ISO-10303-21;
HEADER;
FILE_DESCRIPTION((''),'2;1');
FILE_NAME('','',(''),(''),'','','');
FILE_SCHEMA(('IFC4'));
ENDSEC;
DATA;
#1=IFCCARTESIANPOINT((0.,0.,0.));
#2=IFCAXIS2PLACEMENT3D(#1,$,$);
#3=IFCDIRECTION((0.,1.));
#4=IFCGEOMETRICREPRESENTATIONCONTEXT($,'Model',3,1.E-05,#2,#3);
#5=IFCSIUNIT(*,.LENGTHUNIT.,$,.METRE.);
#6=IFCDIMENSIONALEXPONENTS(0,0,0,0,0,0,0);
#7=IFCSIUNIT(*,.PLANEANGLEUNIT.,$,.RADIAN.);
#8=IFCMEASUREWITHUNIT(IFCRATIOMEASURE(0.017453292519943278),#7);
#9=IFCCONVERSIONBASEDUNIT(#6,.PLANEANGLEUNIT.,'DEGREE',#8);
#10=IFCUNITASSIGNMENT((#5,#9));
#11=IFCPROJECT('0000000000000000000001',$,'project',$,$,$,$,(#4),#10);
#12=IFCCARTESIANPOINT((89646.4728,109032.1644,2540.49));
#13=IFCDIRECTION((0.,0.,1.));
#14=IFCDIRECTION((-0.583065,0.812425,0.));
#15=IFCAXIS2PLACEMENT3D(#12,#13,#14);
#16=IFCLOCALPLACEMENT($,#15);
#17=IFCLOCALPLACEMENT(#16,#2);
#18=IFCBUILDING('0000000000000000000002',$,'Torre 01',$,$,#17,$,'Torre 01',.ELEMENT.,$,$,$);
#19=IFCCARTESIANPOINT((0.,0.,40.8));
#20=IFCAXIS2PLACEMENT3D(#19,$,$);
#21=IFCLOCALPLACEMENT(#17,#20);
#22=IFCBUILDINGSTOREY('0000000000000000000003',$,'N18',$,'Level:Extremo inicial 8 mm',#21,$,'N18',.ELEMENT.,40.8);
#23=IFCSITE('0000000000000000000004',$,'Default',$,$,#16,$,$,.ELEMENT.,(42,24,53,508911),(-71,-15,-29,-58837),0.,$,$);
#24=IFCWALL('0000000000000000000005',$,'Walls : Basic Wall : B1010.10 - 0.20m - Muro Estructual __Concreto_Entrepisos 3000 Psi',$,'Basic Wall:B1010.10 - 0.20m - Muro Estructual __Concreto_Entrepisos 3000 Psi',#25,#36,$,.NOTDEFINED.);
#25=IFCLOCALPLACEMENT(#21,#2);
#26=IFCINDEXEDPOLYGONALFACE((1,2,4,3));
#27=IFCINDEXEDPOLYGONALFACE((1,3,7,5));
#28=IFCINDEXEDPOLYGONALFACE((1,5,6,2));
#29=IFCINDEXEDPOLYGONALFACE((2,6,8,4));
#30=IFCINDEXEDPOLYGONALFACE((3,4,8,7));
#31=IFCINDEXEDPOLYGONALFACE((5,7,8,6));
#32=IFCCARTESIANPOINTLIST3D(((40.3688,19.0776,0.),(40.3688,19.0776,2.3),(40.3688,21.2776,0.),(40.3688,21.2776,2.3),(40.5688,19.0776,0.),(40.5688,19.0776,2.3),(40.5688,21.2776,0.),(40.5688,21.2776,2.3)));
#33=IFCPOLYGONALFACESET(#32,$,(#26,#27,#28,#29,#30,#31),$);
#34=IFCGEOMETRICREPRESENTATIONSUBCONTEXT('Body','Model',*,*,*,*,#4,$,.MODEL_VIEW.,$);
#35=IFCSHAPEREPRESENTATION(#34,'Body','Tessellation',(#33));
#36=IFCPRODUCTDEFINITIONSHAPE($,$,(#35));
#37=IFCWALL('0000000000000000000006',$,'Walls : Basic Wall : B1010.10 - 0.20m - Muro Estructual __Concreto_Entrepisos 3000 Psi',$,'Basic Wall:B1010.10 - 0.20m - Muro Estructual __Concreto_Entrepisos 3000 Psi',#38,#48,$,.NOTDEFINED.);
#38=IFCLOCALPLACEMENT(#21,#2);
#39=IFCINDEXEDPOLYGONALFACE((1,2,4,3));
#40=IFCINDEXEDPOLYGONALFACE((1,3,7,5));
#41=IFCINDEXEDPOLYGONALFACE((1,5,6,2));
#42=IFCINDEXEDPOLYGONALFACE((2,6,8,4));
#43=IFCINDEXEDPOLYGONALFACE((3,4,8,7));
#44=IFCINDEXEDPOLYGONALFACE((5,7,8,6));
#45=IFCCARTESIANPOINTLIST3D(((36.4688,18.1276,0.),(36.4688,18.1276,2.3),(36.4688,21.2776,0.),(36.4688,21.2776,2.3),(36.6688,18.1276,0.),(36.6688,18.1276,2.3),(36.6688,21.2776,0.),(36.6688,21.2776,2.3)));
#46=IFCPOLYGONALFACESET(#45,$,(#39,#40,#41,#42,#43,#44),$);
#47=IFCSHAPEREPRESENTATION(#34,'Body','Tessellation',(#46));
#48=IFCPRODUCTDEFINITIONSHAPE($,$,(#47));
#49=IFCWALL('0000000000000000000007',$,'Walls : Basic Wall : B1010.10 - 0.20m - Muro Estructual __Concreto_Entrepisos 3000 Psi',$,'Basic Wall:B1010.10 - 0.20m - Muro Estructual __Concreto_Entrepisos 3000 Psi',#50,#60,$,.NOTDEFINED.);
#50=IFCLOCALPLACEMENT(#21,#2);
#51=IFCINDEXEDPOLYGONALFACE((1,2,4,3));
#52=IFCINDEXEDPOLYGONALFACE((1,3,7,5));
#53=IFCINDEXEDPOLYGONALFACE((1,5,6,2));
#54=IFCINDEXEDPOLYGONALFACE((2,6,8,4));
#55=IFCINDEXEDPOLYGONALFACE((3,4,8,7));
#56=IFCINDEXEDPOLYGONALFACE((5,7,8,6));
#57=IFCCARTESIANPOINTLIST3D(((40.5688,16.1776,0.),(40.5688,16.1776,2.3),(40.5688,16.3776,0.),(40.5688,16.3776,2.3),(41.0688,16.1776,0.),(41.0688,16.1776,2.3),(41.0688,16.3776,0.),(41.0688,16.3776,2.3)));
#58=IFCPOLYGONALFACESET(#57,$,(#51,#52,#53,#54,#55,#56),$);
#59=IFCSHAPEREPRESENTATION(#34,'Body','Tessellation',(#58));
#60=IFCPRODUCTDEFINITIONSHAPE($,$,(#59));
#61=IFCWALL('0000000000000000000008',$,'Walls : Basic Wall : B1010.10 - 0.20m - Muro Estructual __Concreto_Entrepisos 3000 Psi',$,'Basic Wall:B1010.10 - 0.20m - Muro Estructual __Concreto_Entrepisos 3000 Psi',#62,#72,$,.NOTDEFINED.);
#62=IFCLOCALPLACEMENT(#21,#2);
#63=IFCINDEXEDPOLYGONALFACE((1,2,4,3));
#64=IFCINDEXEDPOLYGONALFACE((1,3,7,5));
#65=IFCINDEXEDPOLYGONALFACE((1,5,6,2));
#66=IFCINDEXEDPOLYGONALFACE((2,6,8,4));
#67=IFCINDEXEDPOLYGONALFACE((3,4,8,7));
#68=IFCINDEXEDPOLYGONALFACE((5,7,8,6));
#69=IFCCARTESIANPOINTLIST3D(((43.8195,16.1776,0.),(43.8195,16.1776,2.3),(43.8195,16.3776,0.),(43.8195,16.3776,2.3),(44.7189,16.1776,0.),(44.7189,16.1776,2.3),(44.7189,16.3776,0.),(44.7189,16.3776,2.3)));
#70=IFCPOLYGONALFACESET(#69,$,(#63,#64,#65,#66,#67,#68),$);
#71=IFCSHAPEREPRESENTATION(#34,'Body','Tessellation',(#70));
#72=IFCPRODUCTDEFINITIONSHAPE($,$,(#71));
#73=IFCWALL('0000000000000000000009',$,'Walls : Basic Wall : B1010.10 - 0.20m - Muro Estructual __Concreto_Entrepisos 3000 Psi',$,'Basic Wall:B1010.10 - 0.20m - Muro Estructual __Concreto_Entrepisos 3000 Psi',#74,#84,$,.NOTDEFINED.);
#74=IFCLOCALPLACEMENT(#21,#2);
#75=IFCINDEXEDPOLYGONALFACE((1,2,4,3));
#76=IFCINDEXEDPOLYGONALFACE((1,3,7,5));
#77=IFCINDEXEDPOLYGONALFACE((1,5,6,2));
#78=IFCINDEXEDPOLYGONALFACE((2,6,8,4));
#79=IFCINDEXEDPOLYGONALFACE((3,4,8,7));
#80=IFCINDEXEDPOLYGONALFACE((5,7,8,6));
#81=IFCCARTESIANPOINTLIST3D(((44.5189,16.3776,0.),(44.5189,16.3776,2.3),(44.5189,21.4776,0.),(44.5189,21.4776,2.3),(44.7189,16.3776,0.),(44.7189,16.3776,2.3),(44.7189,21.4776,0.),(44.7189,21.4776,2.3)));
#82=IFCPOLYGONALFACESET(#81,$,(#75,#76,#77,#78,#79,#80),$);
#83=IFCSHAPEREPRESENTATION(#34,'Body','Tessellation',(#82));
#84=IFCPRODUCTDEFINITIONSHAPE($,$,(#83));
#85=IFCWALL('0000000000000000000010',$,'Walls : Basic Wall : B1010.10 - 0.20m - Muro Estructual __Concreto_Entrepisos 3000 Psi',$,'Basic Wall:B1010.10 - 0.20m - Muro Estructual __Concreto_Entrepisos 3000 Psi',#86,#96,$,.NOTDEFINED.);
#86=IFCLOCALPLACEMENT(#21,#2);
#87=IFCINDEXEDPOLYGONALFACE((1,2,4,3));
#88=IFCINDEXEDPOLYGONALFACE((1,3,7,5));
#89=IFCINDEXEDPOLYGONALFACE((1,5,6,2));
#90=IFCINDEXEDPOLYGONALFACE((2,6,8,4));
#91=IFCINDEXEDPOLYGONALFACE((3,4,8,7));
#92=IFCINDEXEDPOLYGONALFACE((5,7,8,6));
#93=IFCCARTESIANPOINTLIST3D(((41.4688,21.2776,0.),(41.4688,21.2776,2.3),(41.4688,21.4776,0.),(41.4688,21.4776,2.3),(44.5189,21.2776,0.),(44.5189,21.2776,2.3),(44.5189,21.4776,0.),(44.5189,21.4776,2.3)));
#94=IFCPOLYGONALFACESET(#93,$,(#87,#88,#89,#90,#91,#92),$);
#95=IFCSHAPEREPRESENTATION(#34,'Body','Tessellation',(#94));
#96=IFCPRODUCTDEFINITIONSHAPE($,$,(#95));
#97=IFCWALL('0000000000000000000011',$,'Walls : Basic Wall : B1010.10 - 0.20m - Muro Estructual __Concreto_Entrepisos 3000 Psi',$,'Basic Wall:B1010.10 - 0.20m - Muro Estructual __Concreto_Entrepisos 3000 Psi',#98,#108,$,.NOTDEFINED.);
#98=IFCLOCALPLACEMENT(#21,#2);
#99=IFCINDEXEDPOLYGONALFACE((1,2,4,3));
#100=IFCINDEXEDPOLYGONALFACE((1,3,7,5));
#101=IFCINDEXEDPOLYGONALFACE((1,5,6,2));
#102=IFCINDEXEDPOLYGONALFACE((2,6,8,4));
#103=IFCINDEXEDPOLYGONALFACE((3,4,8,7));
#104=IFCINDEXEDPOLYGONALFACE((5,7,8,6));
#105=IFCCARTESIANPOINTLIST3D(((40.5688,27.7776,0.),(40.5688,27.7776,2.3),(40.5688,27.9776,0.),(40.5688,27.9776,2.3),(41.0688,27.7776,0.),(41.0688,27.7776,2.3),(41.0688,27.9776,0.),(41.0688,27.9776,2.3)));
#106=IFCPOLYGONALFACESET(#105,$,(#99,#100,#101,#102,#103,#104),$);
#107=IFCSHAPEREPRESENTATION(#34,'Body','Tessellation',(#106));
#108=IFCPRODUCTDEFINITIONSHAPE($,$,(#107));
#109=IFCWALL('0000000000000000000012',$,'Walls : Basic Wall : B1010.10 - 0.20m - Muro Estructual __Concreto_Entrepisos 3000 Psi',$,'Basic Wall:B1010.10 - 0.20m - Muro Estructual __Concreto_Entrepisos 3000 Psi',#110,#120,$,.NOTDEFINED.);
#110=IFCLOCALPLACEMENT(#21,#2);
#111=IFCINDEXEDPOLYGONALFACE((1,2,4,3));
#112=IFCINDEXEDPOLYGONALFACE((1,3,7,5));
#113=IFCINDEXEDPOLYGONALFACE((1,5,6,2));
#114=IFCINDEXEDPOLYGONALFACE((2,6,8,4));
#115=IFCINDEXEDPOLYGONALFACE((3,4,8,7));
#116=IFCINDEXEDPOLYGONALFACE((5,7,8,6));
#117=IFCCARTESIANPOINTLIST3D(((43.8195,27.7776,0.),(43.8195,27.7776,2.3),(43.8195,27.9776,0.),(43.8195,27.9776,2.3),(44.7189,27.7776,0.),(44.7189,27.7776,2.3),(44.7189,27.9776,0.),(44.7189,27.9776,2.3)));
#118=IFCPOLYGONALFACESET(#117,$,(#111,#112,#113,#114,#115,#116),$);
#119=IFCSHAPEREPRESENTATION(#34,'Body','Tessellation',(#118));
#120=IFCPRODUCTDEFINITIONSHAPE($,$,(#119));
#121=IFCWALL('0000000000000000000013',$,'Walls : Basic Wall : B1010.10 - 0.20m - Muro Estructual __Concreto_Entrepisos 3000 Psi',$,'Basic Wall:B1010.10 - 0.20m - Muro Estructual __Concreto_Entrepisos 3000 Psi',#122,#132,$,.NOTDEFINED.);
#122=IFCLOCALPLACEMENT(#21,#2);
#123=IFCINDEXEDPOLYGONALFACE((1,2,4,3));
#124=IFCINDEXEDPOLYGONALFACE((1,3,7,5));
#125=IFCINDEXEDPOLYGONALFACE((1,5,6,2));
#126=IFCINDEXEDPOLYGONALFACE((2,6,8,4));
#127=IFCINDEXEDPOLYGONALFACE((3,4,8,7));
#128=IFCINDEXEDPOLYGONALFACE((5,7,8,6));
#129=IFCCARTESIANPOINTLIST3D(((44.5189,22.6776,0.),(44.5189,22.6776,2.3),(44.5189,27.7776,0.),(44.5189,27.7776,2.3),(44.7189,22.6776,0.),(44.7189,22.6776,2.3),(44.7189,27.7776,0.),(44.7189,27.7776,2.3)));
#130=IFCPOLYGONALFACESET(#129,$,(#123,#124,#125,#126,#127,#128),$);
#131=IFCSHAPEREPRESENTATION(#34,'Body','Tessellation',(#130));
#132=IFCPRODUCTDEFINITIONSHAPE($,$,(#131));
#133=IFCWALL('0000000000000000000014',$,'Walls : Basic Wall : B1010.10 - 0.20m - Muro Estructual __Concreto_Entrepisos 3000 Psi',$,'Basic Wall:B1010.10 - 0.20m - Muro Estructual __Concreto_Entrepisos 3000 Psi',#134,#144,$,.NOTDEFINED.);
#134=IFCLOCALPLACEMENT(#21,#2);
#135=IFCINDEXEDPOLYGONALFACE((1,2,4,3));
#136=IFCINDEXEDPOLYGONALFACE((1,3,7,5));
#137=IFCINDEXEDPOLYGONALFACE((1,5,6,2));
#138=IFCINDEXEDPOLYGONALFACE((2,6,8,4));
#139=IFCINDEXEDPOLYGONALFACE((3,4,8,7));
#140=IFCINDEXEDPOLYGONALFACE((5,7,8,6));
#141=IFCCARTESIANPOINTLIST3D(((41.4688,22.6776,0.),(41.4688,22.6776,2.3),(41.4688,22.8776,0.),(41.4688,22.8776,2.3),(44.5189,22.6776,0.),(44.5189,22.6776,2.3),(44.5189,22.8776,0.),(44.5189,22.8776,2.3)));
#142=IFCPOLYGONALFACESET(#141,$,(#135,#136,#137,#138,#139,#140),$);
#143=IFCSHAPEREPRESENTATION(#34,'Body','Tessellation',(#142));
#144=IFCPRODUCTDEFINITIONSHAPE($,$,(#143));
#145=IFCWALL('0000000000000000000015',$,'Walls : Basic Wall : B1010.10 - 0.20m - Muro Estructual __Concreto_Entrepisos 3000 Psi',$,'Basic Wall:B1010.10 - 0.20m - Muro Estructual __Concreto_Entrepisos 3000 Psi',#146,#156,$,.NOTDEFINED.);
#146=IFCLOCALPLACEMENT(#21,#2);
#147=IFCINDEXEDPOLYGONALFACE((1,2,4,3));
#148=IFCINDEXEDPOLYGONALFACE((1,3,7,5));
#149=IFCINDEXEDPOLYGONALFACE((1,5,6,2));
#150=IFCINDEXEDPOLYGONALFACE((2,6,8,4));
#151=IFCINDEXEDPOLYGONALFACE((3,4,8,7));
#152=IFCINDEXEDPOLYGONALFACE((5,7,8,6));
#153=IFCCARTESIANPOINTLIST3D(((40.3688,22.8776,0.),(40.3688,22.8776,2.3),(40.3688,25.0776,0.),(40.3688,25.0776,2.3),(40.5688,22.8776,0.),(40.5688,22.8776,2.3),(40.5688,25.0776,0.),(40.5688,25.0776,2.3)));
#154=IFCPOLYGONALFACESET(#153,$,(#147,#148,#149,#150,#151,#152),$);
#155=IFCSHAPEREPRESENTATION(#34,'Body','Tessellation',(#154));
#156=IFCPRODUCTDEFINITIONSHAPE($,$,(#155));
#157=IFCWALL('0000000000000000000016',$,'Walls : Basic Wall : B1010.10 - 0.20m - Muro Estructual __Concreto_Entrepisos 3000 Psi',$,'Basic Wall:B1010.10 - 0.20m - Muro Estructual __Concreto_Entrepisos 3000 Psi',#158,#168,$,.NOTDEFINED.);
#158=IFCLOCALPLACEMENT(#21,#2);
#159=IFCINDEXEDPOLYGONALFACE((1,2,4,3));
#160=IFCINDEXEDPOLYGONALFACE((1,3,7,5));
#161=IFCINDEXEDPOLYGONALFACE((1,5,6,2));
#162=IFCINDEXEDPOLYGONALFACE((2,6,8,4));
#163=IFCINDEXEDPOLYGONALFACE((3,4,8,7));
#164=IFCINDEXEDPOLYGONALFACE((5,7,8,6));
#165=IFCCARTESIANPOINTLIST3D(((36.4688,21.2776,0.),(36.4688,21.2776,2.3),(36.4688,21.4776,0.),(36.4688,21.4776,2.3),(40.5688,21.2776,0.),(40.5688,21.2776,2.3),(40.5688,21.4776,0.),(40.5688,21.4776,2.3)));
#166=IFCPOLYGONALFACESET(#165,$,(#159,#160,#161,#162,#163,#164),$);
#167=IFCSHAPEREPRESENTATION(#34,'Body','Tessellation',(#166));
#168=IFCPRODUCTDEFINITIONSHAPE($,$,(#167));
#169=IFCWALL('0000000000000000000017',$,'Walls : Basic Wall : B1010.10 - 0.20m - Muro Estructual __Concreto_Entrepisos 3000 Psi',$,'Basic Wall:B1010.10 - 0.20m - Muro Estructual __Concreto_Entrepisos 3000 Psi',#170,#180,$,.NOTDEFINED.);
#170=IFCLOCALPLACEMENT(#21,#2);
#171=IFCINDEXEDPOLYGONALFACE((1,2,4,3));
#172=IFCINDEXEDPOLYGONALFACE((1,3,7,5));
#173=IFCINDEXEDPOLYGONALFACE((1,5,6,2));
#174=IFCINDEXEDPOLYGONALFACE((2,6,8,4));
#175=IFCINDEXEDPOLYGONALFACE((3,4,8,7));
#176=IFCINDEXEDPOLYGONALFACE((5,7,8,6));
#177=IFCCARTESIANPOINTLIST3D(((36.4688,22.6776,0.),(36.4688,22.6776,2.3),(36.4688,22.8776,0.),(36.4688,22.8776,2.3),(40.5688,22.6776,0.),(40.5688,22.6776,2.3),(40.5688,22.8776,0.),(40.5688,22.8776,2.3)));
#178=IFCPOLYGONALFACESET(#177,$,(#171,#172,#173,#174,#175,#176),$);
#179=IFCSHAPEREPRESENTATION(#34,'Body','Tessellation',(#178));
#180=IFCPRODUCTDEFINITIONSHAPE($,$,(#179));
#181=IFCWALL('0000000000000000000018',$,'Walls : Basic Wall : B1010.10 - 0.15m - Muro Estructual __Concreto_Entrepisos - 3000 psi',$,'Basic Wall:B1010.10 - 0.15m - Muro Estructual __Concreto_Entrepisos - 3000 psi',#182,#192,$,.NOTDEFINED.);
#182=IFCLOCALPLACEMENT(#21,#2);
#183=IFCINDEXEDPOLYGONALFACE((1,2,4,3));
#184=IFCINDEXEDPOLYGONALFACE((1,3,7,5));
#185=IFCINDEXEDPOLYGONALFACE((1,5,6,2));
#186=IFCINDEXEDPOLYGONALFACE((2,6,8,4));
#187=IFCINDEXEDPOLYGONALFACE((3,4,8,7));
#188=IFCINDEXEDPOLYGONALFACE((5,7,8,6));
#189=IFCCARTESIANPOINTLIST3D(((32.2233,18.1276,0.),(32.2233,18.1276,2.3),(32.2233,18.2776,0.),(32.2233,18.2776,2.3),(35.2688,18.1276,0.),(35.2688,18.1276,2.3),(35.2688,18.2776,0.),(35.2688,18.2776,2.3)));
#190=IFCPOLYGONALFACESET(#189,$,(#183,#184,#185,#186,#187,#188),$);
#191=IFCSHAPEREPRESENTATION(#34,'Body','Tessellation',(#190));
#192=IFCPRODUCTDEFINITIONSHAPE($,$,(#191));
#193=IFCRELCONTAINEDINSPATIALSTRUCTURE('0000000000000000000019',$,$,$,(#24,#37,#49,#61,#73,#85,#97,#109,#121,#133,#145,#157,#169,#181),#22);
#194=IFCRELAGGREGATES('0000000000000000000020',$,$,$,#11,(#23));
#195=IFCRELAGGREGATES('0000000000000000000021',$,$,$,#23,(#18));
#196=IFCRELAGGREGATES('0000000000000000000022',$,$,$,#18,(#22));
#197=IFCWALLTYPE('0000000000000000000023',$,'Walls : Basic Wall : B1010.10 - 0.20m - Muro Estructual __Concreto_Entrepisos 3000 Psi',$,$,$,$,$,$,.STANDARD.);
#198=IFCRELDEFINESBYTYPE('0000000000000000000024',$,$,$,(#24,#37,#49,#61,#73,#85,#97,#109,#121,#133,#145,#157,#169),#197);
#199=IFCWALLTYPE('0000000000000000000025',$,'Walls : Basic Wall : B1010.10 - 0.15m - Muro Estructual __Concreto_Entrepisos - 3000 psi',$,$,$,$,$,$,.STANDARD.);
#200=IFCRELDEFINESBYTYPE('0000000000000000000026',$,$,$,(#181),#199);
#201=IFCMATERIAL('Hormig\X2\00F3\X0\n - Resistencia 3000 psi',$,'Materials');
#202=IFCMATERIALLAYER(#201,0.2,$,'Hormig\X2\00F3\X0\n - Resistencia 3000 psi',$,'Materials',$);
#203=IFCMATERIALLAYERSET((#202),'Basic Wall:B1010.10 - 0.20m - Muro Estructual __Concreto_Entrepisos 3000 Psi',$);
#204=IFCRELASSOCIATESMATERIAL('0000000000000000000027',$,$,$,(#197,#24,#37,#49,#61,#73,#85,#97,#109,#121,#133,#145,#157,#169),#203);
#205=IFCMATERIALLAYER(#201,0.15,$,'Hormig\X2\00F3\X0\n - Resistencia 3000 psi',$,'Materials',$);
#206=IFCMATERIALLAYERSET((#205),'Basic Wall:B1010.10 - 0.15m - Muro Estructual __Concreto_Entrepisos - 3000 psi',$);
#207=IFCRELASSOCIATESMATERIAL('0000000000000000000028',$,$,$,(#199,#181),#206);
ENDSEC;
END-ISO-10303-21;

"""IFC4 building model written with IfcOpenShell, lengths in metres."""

from ifc_helpers import new_model, entity, si_unit, converted_unit, direction, frame, frame_2d, origin, place, context, subcontext, project, spatial, rectangle, extrude, material, layer, layer_set, layer_usage, type_object, element, save


model = new_model("IFC4")

# Units and contexts
model_context = context("Model", 3, precision=1e-05, world=origin(), true_north=direction((0.0, 1.0)))
body_context = subcontext(model_context, "Body", "Model", "MODEL_VIEW")
ifc_project = project(units=[si_unit("LENGTHUNIT", "METRE"), converted_unit("PLANEANGLEUNIT", "DEGREE", entity("IfcRatioMeasure", 0.017453292519943278), si_unit("PLANEANGLEUNIT", "RADIAN"), dimensions=[0, 0, 0, 0, 0, 0, 0])], contexts=[model_context])

# Site, building, storey
site_placement = place(None, frame((89646.4728, 109032.1644, 2540.49), z_axis=(0.0, 0.0, 1.0), x_axis=(-0.583065, 0.812425, 0.0)))
site = spatial("IfcSite", under=ifc_project, at=site_placement, Name="Default", CompositionType="ELEMENT", RefLatitude=(42, 24, 53, 508911), RefLongitude=(-71, -15, -29, -58837), RefElevation=0.0)
building_placement = place(site_placement, origin())
building = spatial("IfcBuilding", under=site, at=building_placement, Name="Torre 01", LongName="Torre 01", CompositionType="ELEMENT")
storey_placement = place(building_placement, frame((0.0, 0.0, 40.8)))
storey = spatial("IfcBuildingStorey", under=building, at=storey_placement, Name="N18", ObjectType="Level:Extremo inicial 8 mm", LongName="N18", CompositionType="ELEMENT", Elevation=40.8)

# Walls
ifc_material = material(Name="Hormigón - Resistencia 3000 psi", Category="Materials")
ifc_layer_1 = layer(ifc_material, 0.2, Name="Hormigón - Resistencia 3000 psi", Category="Materials")
ifc_layer_set_1 = layer_set([ifc_layer_1], Name="Basic Wall:B1010.10 - 0.20m - Muro Estructual __Concreto_Entrepisos 3000 Psi")
ifc_layer_usage_1 = layer_usage(ifc_layer_set_1, "AXIS2", "NEGATIVE", 0.1)
wall_type_1 = type_object("IfcWallType", Name="Walls : Basic Wall : B1010.10 - 0.20m - Muro Estructual __Concreto_Entrepisos 3000 Psi", PredefinedType="STANDARD", material=ifc_layer_set_1)
wall_1_placement = place(storey_placement, frame((40.4688, 21.2776, 0.0), z_axis=(0.0, 0.0, 1.0), x_axis=(0.0, -1.0, 0.0)))
element("IfcWall", 1, at=wall_1_placement, inside=storey, type_object=wall_type_1, material=ifc_layer_usage_1, Name="Walls : Basic Wall : B1010.10 - 0.20m - Muro Estructual __Concreto_Entrepisos 3000 Psi", ObjectType="Basic Wall:B1010.10 - 0.20m - Muro Estructual __Concreto_Entrepisos 3000 Psi", PredefinedType="NOTDEFINED", context=body_context, shape_type="SweptSolid", body=[
    extrude(rectangle(XDim=2.2, YDim=0.2, at=frame_2d((1.1, 0.0), x_axis=(-1.0, 0.0))), origin(), (0.0, 0.0, 1.0), 2.3),
])
ifc_layer_usage_2 = layer_usage(ifc_layer_set_1, "AXIS2", "NEGATIVE", 0.1)
wall_2_placement = place(storey_placement, frame((36.5688, 18.1276, 0.0), z_axis=(0.0, 0.0, 1.0), x_axis=(0.0, 1.0, 0.0)))
element("IfcWall", 2, at=wall_2_placement, inside=storey, type_object=wall_type_1, material=ifc_layer_usage_2, Name="Walls : Basic Wall : B1010.10 - 0.20m - Muro Estructual __Concreto_Entrepisos 3000 Psi", ObjectType="Basic Wall:B1010.10 - 0.20m - Muro Estructual __Concreto_Entrepisos 3000 Psi", PredefinedType="NOTDEFINED", context=body_context, shape_type="SweptSolid", body=[
    extrude(rectangle(XDim=3.15, YDim=0.2, at=frame_2d((1.575, 0.0), x_axis=(-1.0, 0.0))), origin(), (0.0, 0.0, 1.0), 2.3),
])
ifc_layer_usage_3 = layer_usage(ifc_layer_set_1, "AXIS2", "NEGATIVE", 0.1)
wall_3_placement = place(storey_placement, frame((41.0688, 16.2776, 0.0), z_axis=(0.0, 0.0, 1.0), x_axis=(-1.0, 0.0, 0.0)))
element("IfcWall", 3, at=wall_3_placement, inside=storey, type_object=wall_type_1, material=ifc_layer_usage_3, Name="Walls : Basic Wall : B1010.10 - 0.20m - Muro Estructual __Concreto_Entrepisos 3000 Psi", ObjectType="Basic Wall:B1010.10 - 0.20m - Muro Estructual __Concreto_Entrepisos 3000 Psi", PredefinedType="NOTDEFINED", context=body_context, shape_type="SweptSolid", body=[
    extrude(rectangle(XDim=0.5, YDim=0.2, at=frame_2d((0.25, 0.0), x_axis=(-1.0, 0.0))), origin(), (0.0, 0.0, 1.0), 2.3),
])
ifc_layer_usage_4 = layer_usage(ifc_layer_set_1, "AXIS2", "NEGATIVE", 0.1)
wall_4_placement = place(storey_placement, frame((43.8195, 16.2776, 0.0)))
element("IfcWall", 4, at=wall_4_placement, inside=storey, type_object=wall_type_1, material=ifc_layer_usage_4, Name="Walls : Basic Wall : B1010.10 - 0.20m - Muro Estructual __Concreto_Entrepisos 3000 Psi", ObjectType="Basic Wall:B1010.10 - 0.20m - Muro Estructual __Concreto_Entrepisos 3000 Psi", PredefinedType="NOTDEFINED", context=body_context, shape_type="SweptSolid", body=[
    extrude(rectangle(XDim=0.8993, YDim=0.2, at=frame_2d((0.4497, 0.0), x_axis=(-1.0, 0.0))), origin(), (0.0, 0.0, 1.0), 2.3),
])
ifc_layer_usage_5 = layer_usage(ifc_layer_set_1, "AXIS2", "NEGATIVE", 0.1)
wall_5_placement = place(storey_placement, frame((44.6189, 21.4776, 0.0), z_axis=(0.0, 0.0, 1.0), x_axis=(0.0, -1.0, 0.0)))
element("IfcWall", 5, at=wall_5_placement, inside=storey, type_object=wall_type_1, material=ifc_layer_usage_5, Name="Walls : Basic Wall : B1010.10 - 0.20m - Muro Estructual __Concreto_Entrepisos 3000 Psi", ObjectType="Basic Wall:B1010.10 - 0.20m - Muro Estructual __Concreto_Entrepisos 3000 Psi", PredefinedType="NOTDEFINED", context=body_context, shape_type="SweptSolid", body=[
    extrude(rectangle(XDim=5.1, YDim=0.2, at=frame_2d((2.55, 0.0), x_axis=(-1.0, 0.0))), origin(), (0.0, 0.0, 1.0), 2.3),
])
ifc_layer_usage_6 = layer_usage(ifc_layer_set_1, "AXIS2", "NEGATIVE", 0.1)
wall_6_placement = place(storey_placement, frame((41.4688, 21.3776, 0.0)))
element("IfcWall", 6, at=wall_6_placement, inside=storey, type_object=wall_type_1, material=ifc_layer_usage_6, Name="Walls : Basic Wall : B1010.10 - 0.20m - Muro Estructual __Concreto_Entrepisos 3000 Psi", ObjectType="Basic Wall:B1010.10 - 0.20m - Muro Estructual __Concreto_Entrepisos 3000 Psi", PredefinedType="NOTDEFINED", context=body_context, shape_type="SweptSolid", body=[
    extrude(rectangle(XDim=3.05, YDim=0.2, at=frame_2d((1.525, 0.0), x_axis=(-1.0, 0.0))), origin(), (0.0, 0.0, 1.0), 2.3),
])
ifc_layer_usage_7 = layer_usage(ifc_layer_set_1, "AXIS2", "POSITIVE", -0.1)
wall_7_placement = place(storey_placement, frame((41.0688, 27.8776, 0.0), z_axis=(0.0, 0.0, 1.0), x_axis=(-1.0, 0.0, 0.0)))
element("IfcWall", 7, at=wall_7_placement, inside=storey, type_object=wall_type_1, material=ifc_layer_usage_7, Name="Walls : Basic Wall : B1010.10 - 0.20m - Muro Estructual __Concreto_Entrepisos 3000 Psi", ObjectType="Basic Wall:B1010.10 - 0.20m - Muro Estructual __Concreto_Entrepisos 3000 Psi", PredefinedType="NOTDEFINED", context=body_context, shape_type="SweptSolid", body=[
    extrude(rectangle(XDim=0.5, YDim=0.2, at=frame_2d((0.25, 0.0), x_axis=(-1.0, 0.0))), origin(), (0.0, 0.0, 1.0), 2.3),
])
ifc_layer_usage_8 = layer_usage(ifc_layer_set_1, "AXIS2", "POSITIVE", -0.1)
wall_8_placement = place(storey_placement, frame((43.8195, 27.8776, 0.0)))
element("IfcWall", 8, at=wall_8_placement, inside=storey, type_object=wall_type_1, material=ifc_layer_usage_8, Name="Walls : Basic Wall : B1010.10 - 0.20m - Muro Estructual __Concreto_Entrepisos 3000 Psi", ObjectType="Basic Wall:B1010.10 - 0.20m - Muro Estructual __Concreto_Entrepisos 3000 Psi", PredefinedType="NOTDEFINED", context=body_context, shape_type="SweptSolid", body=[
    extrude(rectangle(XDim=0.8993, YDim=0.2, at=frame_2d((0.4497, 0.0), x_axis=(-1.0, 0.0))), origin(), (0.0, 0.0, 1.0), 2.3),
])
ifc_layer_usage_9 = layer_usage(ifc_layer_set_1, "AXIS2", "POSITIVE", -0.1)
wall_9_placement = place(storey_placement, frame((44.6189, 22.6776, 0.0), z_axis=(0.0, 0.0, 1.0), x_axis=(0.0, 1.0, 0.0)))
element("IfcWall", 9, at=wall_9_placement, inside=storey, type_object=wall_type_1, material=ifc_layer_usage_9, Name="Walls : Basic Wall : B1010.10 - 0.20m - Muro Estructual __Concreto_Entrepisos 3000 Psi", ObjectType="Basic Wall:B1010.10 - 0.20m - Muro Estructual __Concreto_Entrepisos 3000 Psi", PredefinedType="NOTDEFINED", context=body_context, shape_type="SweptSolid", body=[
    extrude(rectangle(XDim=5.1, YDim=0.2, at=frame_2d((2.55, 0.0), x_axis=(-1.0, 0.0))), origin(), (0.0, 0.0, 1.0), 2.3),
])
ifc_layer_usage_10 = layer_usage(ifc_layer_set_1, "AXIS2", "POSITIVE", -0.1)
wall_10_placement = place(storey_placement, frame((41.4688, 22.7776, 0.0)))
element("IfcWall", 10, at=wall_10_placement, inside=storey, type_object=wall_type_1, material=ifc_layer_usage_10, Name="Walls : Basic Wall : B1010.10 - 0.20m - Muro Estructual __Concreto_Entrepisos 3000 Psi", ObjectType="Basic Wall:B1010.10 - 0.20m - Muro Estructual __Concreto_Entrepisos 3000 Psi", PredefinedType="NOTDEFINED", context=body_context, shape_type="SweptSolid", body=[
    extrude(rectangle(XDim=3.05, YDim=0.2, at=frame_2d((1.525, 0.0), x_axis=(-1.0, 0.0))), origin(), (0.0, 0.0, 1.0), 2.3),
])
ifc_layer_usage_11 = layer_usage(ifc_layer_set_1, "AXIS2", "POSITIVE", -0.1)
wall_11_placement = place(storey_placement, frame((40.4688, 22.8776, 0.0), z_axis=(0.0, 0.0, 1.0), x_axis=(0.0, 1.0, 0.0)))
element("IfcWall", 11, at=wall_11_placement, inside=storey, type_object=wall_type_1, material=ifc_layer_usage_11, Name="Walls : Basic Wall : B1010.10 - 0.20m - Muro Estructual __Concreto_Entrepisos 3000 Psi", ObjectType="Basic Wall:B1010.10 - 0.20m - Muro Estructual __Concreto_Entrepisos 3000 Psi", PredefinedType="NOTDEFINED", context=body_context, shape_type="SweptSolid", body=[
    extrude(rectangle(XDim=2.2, YDim=0.2, at=frame_2d((1.1, 0.0), x_axis=(-1.0, 0.0))), origin(), (0.0, 0.0, 1.0), 2.3),
])
ifc_layer_usage_12 = layer_usage(ifc_layer_set_1, "AXIS2", "NEGATIVE", 0.1)
wall_12_placement = place(storey_placement, frame((36.4688, 21.3776, 0.0)))
element("IfcWall", 12, at=wall_12_placement, inside=storey, type_object=wall_type_1, material=ifc_layer_usage_12, Name="Walls : Basic Wall : B1010.10 - 0.20m - Muro Estructual __Concreto_Entrepisos 3000 Psi", ObjectType="Basic Wall:B1010.10 - 0.20m - Muro Estructual __Concreto_Entrepisos 3000 Psi", PredefinedType="NOTDEFINED", context=body_context, shape_type="SweptSolid", body=[
    extrude(rectangle(XDim=4.1, YDim=0.2, at=frame_2d((2.05, 0.0), x_axis=(-1.0, 0.0))), origin(), (0.0, 0.0, 1.0), 2.3),
])
ifc_layer_usage_13 = layer_usage(ifc_layer_set_1, "AXIS2", "POSITIVE", -0.1)
wall_13_placement = place(storey_placement, frame((36.4688, 22.7776, 0.0)))
element("IfcWall", 13, at=wall_13_placement, inside=storey, type_object=wall_type_1, material=ifc_layer_usage_13, Name="Walls : Basic Wall : B1010.10 - 0.20m - Muro Estructual __Concreto_Entrepisos 3000 Psi", ObjectType="Basic Wall:B1010.10 - 0.20m - Muro Estructual __Concreto_Entrepisos 3000 Psi", PredefinedType="NOTDEFINED", context=body_context, shape_type="SweptSolid", body=[
    extrude(rectangle(XDim=4.1, YDim=0.2, at=frame_2d((2.05, 0.0), x_axis=(-1.0, 0.0))), origin(), (0.0, 0.0, 1.0), 2.3),
])
ifc_layer_2 = layer(ifc_material, 0.15, Name="Hormigón - Resistencia 3000 psi", Category="Materials")
ifc_layer_set_2 = layer_set([ifc_layer_2], Name="Basic Wall:B1010.10 - 0.15m - Muro Estructual __Concreto_Entrepisos - 3000 psi")
ifc_layer_usage_14 = layer_usage(ifc_layer_set_2, "AXIS2", "NEGATIVE", 0.075)
wall_type_2 = type_object("IfcWallType", Name="Walls : Basic Wall : B1010.10 - 0.15m - Muro Estructual __Concreto_Entrepisos - 3000 psi", PredefinedType="STANDARD", material=ifc_layer_set_2)
wall_14_placement = place(storey_placement, frame((32.2233, 18.2026, 0.0)))
element("IfcWall", 14, at=wall_14_placement, inside=storey, type_object=wall_type_2, material=ifc_layer_usage_14, Name="Walls : Basic Wall : B1010.10 - 0.15m - Muro Estructual __Concreto_Entrepisos - 3000 psi", ObjectType="Basic Wall:B1010.10 - 0.15m - Muro Estructual __Concreto_Entrepisos - 3000 psi", PredefinedType="NOTDEFINED", context=body_context, shape_type="SweptSolid", body=[
    extrude(rectangle(XDim=3.0455, YDim=0.15, at=frame_2d((1.5228, 0.0), x_axis=(-1.0, 0.0))), origin(), (0.0, 0.0, 1.0), 2.3),
])

save(model, "model.ifc")
